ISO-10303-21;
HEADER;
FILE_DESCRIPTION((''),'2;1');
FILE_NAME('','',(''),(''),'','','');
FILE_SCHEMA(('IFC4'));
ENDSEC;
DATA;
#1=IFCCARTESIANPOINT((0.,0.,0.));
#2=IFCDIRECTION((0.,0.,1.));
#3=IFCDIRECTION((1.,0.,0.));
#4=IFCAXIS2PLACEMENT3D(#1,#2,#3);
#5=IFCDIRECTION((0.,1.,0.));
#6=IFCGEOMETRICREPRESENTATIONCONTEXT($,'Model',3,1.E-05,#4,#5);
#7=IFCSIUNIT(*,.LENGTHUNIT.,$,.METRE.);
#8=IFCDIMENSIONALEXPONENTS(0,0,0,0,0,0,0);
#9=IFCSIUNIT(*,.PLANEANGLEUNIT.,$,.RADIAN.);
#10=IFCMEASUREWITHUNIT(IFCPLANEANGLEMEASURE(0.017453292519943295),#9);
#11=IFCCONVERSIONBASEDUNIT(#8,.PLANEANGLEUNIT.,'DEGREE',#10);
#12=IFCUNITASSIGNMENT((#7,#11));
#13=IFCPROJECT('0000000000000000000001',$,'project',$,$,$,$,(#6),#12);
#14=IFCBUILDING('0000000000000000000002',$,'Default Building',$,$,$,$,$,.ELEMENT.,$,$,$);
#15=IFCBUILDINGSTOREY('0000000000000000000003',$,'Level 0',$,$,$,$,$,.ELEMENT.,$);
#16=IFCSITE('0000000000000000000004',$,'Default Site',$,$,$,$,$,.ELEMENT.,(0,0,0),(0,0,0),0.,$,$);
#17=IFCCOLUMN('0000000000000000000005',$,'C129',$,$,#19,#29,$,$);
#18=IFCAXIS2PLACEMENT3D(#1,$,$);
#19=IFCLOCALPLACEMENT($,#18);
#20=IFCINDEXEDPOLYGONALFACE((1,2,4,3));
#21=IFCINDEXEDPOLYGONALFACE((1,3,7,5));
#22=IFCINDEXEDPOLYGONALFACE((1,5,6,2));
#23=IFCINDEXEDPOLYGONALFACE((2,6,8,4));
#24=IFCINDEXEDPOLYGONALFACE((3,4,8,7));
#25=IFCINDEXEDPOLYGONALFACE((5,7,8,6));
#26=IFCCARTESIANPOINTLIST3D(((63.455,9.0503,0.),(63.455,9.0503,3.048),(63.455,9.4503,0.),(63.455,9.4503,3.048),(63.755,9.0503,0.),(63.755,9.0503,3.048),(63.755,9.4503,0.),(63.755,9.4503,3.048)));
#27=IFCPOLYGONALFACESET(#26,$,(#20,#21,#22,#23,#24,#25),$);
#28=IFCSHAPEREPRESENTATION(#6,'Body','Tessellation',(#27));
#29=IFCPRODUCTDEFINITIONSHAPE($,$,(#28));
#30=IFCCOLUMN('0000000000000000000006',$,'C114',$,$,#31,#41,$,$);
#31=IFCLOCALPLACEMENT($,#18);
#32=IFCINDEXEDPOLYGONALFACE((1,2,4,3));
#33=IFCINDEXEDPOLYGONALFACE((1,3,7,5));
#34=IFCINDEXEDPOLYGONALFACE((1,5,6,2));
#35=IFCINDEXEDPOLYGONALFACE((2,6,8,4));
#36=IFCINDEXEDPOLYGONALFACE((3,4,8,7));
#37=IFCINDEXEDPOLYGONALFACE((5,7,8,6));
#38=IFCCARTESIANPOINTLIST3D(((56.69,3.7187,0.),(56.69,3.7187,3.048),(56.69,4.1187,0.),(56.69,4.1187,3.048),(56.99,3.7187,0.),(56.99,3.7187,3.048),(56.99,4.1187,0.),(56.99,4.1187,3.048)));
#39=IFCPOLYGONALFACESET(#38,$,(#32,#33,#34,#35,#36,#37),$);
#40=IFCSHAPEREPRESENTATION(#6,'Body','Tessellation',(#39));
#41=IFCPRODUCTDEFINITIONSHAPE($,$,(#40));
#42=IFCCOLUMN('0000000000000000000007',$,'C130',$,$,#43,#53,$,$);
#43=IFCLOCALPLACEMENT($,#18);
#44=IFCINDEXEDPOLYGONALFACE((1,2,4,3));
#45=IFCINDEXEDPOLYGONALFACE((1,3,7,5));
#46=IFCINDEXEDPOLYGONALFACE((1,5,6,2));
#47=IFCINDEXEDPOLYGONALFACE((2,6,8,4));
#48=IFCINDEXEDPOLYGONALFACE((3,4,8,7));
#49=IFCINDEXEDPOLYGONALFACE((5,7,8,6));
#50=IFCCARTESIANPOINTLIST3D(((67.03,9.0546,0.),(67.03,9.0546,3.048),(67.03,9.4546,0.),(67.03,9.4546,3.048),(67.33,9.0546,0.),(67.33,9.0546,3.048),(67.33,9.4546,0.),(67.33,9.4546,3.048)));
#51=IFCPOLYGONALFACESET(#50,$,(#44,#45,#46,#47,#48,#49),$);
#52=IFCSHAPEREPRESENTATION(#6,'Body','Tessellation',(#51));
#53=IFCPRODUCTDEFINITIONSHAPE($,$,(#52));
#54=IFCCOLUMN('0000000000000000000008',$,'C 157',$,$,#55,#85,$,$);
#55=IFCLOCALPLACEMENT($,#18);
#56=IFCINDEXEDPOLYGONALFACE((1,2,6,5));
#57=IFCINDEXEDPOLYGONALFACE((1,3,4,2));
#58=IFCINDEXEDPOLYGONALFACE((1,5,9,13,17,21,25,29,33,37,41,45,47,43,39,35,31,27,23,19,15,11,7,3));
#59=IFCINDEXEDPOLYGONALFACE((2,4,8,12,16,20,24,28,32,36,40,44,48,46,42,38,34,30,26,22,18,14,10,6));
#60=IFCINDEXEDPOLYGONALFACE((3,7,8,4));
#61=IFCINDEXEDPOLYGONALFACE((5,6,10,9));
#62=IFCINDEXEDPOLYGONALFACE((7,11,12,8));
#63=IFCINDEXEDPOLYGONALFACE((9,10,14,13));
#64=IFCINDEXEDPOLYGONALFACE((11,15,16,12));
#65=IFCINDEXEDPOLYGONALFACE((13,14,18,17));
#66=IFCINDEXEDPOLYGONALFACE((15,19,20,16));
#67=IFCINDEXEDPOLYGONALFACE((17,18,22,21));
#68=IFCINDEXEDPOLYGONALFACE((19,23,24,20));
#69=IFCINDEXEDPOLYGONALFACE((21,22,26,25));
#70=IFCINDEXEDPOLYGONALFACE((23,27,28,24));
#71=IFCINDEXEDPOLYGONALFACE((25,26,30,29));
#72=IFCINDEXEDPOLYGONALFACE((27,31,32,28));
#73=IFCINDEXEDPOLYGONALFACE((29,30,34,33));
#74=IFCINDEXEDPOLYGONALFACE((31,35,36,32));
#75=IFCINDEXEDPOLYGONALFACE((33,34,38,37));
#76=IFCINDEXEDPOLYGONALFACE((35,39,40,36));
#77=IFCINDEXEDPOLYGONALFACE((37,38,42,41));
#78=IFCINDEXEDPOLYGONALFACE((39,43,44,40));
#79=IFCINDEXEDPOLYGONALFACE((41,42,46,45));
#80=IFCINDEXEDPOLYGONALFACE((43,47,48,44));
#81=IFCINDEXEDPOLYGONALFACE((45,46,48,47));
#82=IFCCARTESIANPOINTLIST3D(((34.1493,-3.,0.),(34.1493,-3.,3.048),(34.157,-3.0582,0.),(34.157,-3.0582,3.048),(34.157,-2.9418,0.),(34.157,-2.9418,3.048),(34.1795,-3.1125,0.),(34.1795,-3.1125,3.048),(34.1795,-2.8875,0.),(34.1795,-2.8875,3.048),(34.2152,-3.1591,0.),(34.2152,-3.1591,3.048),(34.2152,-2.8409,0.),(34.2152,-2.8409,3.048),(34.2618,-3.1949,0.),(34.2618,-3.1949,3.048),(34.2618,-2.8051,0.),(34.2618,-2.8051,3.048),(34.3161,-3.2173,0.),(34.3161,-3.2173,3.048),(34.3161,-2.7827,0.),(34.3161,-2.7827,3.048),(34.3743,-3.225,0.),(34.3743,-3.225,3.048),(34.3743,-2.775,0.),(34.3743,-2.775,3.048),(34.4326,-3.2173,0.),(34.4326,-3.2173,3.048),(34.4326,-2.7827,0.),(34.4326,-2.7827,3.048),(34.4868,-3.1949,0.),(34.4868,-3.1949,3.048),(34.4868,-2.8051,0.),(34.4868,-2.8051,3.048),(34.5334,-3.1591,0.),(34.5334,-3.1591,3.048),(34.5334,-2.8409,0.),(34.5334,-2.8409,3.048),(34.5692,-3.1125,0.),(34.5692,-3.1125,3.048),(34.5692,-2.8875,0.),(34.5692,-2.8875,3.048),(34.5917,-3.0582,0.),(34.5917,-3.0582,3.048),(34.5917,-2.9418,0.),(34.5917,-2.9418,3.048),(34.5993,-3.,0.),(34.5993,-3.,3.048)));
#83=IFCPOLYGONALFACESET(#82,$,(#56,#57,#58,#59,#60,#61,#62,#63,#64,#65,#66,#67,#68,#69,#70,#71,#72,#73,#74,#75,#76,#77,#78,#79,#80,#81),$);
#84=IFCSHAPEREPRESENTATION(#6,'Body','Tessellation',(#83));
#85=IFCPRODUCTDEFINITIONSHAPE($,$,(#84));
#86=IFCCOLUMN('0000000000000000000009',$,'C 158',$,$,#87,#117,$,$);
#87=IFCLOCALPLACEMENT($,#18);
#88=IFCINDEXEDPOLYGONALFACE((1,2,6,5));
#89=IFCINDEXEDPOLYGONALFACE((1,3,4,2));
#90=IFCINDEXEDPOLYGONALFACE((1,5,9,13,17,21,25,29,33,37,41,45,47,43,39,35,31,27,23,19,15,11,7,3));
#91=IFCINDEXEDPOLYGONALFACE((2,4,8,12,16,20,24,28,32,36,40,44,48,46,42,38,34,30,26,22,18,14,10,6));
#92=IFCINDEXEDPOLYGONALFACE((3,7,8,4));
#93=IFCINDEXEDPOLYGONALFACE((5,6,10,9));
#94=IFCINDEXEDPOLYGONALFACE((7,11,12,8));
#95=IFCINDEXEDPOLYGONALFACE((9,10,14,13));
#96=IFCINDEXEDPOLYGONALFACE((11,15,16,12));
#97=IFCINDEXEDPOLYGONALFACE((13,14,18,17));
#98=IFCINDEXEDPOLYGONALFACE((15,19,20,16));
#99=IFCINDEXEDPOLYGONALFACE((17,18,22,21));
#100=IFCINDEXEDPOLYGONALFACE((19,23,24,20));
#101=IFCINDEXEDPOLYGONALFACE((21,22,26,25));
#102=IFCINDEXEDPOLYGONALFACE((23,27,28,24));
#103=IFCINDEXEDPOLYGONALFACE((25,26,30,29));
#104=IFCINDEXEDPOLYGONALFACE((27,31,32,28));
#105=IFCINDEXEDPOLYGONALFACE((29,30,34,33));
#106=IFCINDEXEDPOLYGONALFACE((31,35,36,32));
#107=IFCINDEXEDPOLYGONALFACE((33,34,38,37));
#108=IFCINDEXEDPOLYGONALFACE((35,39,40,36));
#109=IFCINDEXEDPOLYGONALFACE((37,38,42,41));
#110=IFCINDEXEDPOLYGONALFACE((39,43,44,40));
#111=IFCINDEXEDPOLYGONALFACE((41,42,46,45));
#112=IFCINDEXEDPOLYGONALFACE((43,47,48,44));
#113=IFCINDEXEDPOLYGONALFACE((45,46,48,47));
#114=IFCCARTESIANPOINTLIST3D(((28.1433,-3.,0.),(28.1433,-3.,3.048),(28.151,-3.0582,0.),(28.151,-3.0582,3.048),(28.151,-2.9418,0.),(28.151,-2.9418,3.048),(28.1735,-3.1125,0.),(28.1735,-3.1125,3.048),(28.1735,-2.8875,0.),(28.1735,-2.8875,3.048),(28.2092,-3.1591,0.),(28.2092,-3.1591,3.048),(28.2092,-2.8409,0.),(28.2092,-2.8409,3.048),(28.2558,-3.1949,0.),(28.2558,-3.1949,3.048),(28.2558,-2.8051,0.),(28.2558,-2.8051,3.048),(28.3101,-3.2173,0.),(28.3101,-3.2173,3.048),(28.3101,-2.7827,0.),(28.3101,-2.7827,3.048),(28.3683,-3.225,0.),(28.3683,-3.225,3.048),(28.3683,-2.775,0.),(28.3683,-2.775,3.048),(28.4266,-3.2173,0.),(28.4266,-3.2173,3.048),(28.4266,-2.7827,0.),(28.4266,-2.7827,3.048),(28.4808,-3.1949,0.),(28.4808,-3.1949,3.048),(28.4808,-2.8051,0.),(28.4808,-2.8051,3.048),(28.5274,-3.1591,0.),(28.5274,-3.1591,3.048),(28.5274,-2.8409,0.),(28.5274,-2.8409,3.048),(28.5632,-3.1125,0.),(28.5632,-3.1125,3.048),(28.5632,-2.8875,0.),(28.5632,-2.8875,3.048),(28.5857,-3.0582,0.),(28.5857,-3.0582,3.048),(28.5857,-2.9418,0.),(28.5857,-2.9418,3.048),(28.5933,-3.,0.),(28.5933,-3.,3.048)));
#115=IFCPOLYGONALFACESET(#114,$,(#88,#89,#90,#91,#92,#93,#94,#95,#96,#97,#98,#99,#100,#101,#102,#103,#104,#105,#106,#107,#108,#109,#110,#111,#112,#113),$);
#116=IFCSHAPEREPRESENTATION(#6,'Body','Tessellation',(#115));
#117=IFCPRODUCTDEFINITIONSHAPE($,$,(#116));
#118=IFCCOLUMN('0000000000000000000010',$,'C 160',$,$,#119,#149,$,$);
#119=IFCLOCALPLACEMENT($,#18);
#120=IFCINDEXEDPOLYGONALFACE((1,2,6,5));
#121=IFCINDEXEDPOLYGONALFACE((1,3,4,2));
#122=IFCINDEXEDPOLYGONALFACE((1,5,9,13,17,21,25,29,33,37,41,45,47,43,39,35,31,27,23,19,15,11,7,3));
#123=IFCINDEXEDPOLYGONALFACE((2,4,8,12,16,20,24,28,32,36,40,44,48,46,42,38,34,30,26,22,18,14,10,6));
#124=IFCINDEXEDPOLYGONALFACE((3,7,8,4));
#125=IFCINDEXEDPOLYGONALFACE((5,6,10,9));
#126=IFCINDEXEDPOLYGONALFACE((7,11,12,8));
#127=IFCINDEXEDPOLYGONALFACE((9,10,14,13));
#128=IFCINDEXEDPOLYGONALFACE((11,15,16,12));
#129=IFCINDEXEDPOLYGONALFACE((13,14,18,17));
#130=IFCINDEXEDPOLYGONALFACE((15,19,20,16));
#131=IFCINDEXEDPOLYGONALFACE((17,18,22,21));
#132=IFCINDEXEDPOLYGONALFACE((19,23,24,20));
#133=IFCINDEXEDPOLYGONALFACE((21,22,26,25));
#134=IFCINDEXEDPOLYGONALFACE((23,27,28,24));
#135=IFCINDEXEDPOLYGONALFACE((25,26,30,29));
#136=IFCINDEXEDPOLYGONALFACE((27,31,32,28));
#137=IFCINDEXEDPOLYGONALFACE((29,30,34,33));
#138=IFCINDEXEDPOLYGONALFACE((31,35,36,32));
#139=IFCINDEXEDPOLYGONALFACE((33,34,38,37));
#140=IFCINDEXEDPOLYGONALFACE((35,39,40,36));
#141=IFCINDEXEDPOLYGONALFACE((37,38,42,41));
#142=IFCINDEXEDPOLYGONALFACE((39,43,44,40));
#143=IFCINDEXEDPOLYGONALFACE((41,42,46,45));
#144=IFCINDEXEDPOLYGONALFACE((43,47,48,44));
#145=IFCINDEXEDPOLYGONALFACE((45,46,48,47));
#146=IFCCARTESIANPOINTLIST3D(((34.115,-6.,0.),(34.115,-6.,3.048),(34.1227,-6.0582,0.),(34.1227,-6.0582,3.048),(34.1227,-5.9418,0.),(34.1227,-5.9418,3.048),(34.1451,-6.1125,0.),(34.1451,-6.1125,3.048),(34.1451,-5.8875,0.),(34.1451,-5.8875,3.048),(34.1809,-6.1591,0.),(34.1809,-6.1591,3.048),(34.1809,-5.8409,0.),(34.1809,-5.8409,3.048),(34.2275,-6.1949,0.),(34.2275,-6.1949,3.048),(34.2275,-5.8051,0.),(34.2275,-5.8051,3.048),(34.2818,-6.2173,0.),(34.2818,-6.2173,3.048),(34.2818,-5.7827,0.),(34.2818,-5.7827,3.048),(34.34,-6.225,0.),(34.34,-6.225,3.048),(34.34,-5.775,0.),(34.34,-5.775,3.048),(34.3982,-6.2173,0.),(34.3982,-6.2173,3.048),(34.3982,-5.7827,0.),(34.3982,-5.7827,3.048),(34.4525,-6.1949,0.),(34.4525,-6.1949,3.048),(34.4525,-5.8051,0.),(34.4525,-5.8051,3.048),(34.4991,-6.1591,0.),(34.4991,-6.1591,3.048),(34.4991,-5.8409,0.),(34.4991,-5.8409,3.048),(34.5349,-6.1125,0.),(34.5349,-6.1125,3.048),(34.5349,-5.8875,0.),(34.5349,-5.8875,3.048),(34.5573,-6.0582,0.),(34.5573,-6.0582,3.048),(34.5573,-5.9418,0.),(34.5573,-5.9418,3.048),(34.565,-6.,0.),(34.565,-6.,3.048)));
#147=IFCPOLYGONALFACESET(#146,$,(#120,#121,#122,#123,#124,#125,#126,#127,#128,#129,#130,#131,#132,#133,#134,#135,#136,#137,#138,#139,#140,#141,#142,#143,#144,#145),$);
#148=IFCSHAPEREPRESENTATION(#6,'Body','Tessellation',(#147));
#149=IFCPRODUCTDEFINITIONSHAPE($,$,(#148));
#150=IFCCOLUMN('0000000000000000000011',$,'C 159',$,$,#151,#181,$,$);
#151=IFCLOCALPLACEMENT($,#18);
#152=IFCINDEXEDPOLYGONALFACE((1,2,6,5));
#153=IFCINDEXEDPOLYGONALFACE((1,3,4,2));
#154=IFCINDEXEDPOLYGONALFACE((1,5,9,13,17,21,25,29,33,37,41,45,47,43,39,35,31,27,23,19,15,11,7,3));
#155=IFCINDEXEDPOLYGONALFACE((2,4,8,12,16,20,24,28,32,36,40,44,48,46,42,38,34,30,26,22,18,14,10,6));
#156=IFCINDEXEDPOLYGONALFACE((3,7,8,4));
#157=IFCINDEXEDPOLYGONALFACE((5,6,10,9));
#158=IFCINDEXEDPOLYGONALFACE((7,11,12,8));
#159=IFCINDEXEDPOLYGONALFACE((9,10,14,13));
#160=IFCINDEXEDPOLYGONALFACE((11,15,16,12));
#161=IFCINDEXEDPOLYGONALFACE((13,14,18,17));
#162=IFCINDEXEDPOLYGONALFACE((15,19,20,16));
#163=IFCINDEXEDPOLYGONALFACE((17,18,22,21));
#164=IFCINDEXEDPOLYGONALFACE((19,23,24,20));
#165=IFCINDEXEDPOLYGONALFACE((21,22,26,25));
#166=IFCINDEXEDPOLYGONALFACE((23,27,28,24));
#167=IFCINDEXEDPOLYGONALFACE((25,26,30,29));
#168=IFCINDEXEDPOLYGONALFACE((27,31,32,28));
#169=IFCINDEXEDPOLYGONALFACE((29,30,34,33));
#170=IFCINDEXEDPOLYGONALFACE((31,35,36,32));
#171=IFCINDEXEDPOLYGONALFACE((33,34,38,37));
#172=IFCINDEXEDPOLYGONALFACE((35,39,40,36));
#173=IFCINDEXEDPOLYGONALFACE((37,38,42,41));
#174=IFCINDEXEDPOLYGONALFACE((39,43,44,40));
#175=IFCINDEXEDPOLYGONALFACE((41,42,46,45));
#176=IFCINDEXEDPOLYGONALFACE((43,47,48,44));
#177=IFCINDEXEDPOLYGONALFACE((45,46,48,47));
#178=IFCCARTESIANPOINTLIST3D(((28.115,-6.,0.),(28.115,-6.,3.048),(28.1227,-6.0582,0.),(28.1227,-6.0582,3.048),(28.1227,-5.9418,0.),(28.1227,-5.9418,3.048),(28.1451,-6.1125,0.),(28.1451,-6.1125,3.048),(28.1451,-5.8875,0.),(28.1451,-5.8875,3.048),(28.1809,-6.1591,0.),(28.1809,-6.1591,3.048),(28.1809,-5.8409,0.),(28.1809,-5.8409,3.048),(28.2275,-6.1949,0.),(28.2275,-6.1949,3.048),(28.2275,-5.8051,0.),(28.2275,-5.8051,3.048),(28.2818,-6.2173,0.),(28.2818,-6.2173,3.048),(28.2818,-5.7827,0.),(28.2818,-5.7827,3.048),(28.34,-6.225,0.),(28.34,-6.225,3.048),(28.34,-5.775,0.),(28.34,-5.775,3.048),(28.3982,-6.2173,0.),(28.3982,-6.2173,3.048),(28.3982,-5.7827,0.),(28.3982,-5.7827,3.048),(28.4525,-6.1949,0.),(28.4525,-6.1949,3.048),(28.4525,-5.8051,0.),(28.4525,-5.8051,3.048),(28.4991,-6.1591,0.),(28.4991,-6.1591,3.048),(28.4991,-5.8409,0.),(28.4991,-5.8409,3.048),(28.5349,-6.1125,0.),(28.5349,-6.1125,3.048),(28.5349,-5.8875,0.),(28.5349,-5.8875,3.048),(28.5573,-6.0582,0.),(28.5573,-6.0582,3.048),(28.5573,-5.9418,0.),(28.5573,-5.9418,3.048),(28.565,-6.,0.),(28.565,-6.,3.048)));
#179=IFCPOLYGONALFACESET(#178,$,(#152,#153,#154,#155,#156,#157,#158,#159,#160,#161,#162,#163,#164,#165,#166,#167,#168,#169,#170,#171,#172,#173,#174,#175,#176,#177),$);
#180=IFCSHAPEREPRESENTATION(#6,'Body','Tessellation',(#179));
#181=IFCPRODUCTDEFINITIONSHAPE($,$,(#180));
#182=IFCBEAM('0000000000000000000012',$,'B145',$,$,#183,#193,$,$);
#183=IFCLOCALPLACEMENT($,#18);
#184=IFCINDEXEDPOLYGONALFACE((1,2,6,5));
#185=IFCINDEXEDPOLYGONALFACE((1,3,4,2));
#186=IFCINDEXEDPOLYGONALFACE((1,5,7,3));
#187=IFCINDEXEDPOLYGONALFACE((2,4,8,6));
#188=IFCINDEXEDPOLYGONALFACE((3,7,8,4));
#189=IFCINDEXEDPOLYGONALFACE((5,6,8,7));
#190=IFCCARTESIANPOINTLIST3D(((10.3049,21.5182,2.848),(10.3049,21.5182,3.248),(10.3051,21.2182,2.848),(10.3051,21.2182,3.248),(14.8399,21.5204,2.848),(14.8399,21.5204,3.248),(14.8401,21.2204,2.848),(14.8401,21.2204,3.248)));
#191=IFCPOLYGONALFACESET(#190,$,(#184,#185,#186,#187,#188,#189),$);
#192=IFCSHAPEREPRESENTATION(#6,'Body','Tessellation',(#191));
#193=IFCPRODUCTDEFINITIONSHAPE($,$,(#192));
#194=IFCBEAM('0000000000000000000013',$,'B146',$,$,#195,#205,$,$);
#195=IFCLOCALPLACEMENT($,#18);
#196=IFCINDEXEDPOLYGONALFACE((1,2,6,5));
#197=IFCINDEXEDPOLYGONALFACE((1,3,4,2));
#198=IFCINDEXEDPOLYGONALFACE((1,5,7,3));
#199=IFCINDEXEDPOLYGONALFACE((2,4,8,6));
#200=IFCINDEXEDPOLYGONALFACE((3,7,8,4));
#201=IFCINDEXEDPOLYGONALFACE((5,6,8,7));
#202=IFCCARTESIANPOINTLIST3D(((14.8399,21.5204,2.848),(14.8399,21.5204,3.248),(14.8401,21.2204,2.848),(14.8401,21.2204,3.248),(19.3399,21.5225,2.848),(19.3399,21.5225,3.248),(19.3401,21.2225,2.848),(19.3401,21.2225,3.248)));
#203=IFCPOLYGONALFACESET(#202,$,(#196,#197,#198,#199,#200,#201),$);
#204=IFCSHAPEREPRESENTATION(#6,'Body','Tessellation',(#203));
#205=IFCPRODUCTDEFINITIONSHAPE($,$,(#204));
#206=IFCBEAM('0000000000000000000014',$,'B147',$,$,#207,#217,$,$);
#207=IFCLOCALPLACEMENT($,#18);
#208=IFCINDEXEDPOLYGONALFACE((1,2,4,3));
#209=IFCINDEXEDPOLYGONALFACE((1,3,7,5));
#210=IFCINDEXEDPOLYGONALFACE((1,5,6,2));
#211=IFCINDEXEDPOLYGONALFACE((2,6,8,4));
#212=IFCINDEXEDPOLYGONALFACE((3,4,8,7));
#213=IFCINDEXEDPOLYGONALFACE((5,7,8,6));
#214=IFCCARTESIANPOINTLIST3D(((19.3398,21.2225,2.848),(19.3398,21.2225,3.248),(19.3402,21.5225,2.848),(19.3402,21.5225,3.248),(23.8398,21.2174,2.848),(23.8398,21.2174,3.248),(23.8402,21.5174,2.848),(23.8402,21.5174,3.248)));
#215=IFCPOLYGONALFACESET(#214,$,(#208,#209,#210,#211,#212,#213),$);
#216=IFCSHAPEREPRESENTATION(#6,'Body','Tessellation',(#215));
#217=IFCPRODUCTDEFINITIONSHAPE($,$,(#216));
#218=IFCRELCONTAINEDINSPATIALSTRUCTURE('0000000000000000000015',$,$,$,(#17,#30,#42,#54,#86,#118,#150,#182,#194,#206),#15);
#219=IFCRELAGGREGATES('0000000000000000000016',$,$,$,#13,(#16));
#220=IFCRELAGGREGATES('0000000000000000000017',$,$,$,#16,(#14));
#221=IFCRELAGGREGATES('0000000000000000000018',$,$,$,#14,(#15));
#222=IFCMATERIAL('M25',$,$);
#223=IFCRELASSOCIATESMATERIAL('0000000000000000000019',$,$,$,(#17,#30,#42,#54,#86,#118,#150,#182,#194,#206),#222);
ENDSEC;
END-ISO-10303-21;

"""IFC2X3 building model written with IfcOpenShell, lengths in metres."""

from ifc_helpers import new_model, entity, si_unit, converted_unit, direction, frame, frame_2d, origin_with_axes, origin_2d_with_axis, place, context, project, spatial, rectangle, circle, extrude, material, element, save


model = new_model("IFC2X3")

# Units and contexts
model_context = context("Model", 3, precision=1e-05, world=origin_with_axes(), true_north=direction((0.0, 1.0, 0.0)))
ifc_project = project(units=[si_unit("LENGTHUNIT", "METRE"), converted_unit("PLANEANGLEUNIT", "DEGREE", entity("IfcPlaneAngleMeasure", 0.017453292519943295), si_unit("PLANEANGLEUNIT", "RADIAN"), dimensions=[0, 0, 0, 0, 0, 0, 0])], contexts=[model_context])

# Site, building, storey
site = spatial("IfcSite", under=ifc_project, Name="Default Site", CompositionType="ELEMENT", RefLatitude=(0, 0, 0), RefLongitude=(0, 0, 0), RefElevation=0.0)
building = spatial("IfcBuilding", under=site, Name="Default Building", CompositionType="ELEMENT")
storey = spatial("IfcBuildingStorey", under=building, Name="Level 0", CompositionType="ELEMENT")

# Columns
ifc_material = material(Name="M25")
placement = place(None, origin_with_axes())
element("IfcColumn", 1, at=placement, inside=storey, material=ifc_material, Name="C129", context=model_context, shape_type="SweptSolid", body=[
    extrude(rectangle(XDim=0.3, YDim=0.4, at=frame_2d((0.0, 0.0), x_axis=(1.0, 0.0, 0.0))), frame((63.605, 9.2503, 0.0), z_axis=(0.0, 0.0, 1.0), x_axis=(1.0, 0.0, 0.0)), (0.0, 0.0, 1.0), 3.048),
])
element("IfcColumn", 2, at=placement, inside=storey, material=ifc_material, Name="C114", context=model_context, shape_type="SweptSolid", body=[
    extrude(rectangle(XDim=0.3, YDim=0.4, at=frame_2d((0.0, 0.0), x_axis=(1.0, 0.0, 0.0))), frame((56.84, 3.9187, 0.0), z_axis=(0.0, 0.0, 1.0), x_axis=(1.0, 0.0, 0.0)), (0.0, 0.0, 1.0), 3.048),
])
element("IfcColumn", 3, at=placement, inside=storey, material=ifc_material, Name="C130", context=model_context, shape_type="SweptSolid", body=[
    extrude(rectangle(XDim=0.3, YDim=0.4, at=frame_2d((0.0, 0.0), x_axis=(1.0, 0.0, 0.0))), frame((67.18, 9.2546, 0.0), z_axis=(0.0, 0.0, 1.0), x_axis=(1.0, 0.0, 0.0)), (0.0, 0.0, 1.0), 3.048),
])
element("IfcColumn", 4, at=placement, inside=storey, material=ifc_material, Name="C 157", context=model_context, shape_type="SweptSolid", body=[
    extrude(circle(Radius=0.225, at=origin_2d_with_axis()), frame((34.3743, -3.0, 0.0), z_axis=(0.0, 0.0, 1.0), x_axis=(1.0, 0.0, 0.0)), (0.0, 0.0, 1.0), 3.048),
])
element("IfcColumn", 5, at=placement, inside=storey, material=ifc_material, Name="C 158", context=model_context, shape_type="SweptSolid", body=[
    extrude(circle(Radius=0.225, at=origin_2d_with_axis()), frame((28.3683, -3.0, 0.0), z_axis=(0.0, 0.0, 1.0), x_axis=(1.0, 0.0, 0.0)), (0.0, 0.0, 1.0), 3.048),
])
element("IfcColumn", 6, at=placement, inside=storey, material=ifc_material, Name="C 160", context=model_context, shape_type="SweptSolid", body=[
    extrude(circle(Radius=0.225, at=origin_2d_with_axis()), frame((34.34, -6.0, 0.0), z_axis=(0.0, 0.0, 1.0), x_axis=(1.0, 0.0, 0.0)), (0.0, 0.0, 1.0), 3.048),
])
element("IfcColumn", 7, at=placement, inside=storey, material=ifc_material, Name="C 159", context=model_context, shape_type="SweptSolid", body=[
    extrude(circle(Radius=0.225, at=origin_2d_with_axis()), frame((28.34, -6.0, 0.0), z_axis=(0.0, 0.0, 1.0), x_axis=(1.0, 0.0, 0.0)), (0.0, 0.0, 1.0), 3.048),
])

# Beams
element("IfcBeam", 8, at=placement, inside=storey, material=ifc_material, Name="B145", context=model_context, shape_type="SweptSolid", body=[
    extrude(rectangle(XDim=0.3, YDim=0.4, at=frame_2d((0.0, 0.0), x_axis=(0.0, 1.0, 0.0))), frame((10.305, 21.3682, 3.048), z_axis=(1.0, 0.000476, 0.0), x_axis=(0.0, 0.0, -1.0)), (0.0, 0.0, 1.0), 4.535),
])
element("IfcBeam", 9, at=placement, inside=storey, material=ifc_material, Name="B146", context=model_context, shape_type="SweptSolid", body=[
    extrude(rectangle(XDim=0.3, YDim=0.4, at=frame_2d((0.0, 0.0), x_axis=(0.0, 1.0, 0.0))), frame((14.84, 21.3704, 3.048), z_axis=(1.0, 0.000471, 0.0), x_axis=(0.0, 0.0, -1.0)), (0.0, 0.0, 1.0), 4.5),
])
element("IfcBeam", 10, at=placement, inside=storey, material=ifc_material, Name="B147", context=model_context, shape_type="SweptSolid", body=[
    extrude(rectangle(XDim=0.3, YDim=0.4, at=frame_2d((0.0, 0.0), x_axis=(0.0, 1.0, 0.0))), frame((19.34, 21.3725, 3.048), z_axis=(0.999999, -0.001141, 0.0), x_axis=(0.0, 0.0, -1.0)), (0.0, 0.0, 1.0), 4.5),
])

save(model, "model.ifc")
